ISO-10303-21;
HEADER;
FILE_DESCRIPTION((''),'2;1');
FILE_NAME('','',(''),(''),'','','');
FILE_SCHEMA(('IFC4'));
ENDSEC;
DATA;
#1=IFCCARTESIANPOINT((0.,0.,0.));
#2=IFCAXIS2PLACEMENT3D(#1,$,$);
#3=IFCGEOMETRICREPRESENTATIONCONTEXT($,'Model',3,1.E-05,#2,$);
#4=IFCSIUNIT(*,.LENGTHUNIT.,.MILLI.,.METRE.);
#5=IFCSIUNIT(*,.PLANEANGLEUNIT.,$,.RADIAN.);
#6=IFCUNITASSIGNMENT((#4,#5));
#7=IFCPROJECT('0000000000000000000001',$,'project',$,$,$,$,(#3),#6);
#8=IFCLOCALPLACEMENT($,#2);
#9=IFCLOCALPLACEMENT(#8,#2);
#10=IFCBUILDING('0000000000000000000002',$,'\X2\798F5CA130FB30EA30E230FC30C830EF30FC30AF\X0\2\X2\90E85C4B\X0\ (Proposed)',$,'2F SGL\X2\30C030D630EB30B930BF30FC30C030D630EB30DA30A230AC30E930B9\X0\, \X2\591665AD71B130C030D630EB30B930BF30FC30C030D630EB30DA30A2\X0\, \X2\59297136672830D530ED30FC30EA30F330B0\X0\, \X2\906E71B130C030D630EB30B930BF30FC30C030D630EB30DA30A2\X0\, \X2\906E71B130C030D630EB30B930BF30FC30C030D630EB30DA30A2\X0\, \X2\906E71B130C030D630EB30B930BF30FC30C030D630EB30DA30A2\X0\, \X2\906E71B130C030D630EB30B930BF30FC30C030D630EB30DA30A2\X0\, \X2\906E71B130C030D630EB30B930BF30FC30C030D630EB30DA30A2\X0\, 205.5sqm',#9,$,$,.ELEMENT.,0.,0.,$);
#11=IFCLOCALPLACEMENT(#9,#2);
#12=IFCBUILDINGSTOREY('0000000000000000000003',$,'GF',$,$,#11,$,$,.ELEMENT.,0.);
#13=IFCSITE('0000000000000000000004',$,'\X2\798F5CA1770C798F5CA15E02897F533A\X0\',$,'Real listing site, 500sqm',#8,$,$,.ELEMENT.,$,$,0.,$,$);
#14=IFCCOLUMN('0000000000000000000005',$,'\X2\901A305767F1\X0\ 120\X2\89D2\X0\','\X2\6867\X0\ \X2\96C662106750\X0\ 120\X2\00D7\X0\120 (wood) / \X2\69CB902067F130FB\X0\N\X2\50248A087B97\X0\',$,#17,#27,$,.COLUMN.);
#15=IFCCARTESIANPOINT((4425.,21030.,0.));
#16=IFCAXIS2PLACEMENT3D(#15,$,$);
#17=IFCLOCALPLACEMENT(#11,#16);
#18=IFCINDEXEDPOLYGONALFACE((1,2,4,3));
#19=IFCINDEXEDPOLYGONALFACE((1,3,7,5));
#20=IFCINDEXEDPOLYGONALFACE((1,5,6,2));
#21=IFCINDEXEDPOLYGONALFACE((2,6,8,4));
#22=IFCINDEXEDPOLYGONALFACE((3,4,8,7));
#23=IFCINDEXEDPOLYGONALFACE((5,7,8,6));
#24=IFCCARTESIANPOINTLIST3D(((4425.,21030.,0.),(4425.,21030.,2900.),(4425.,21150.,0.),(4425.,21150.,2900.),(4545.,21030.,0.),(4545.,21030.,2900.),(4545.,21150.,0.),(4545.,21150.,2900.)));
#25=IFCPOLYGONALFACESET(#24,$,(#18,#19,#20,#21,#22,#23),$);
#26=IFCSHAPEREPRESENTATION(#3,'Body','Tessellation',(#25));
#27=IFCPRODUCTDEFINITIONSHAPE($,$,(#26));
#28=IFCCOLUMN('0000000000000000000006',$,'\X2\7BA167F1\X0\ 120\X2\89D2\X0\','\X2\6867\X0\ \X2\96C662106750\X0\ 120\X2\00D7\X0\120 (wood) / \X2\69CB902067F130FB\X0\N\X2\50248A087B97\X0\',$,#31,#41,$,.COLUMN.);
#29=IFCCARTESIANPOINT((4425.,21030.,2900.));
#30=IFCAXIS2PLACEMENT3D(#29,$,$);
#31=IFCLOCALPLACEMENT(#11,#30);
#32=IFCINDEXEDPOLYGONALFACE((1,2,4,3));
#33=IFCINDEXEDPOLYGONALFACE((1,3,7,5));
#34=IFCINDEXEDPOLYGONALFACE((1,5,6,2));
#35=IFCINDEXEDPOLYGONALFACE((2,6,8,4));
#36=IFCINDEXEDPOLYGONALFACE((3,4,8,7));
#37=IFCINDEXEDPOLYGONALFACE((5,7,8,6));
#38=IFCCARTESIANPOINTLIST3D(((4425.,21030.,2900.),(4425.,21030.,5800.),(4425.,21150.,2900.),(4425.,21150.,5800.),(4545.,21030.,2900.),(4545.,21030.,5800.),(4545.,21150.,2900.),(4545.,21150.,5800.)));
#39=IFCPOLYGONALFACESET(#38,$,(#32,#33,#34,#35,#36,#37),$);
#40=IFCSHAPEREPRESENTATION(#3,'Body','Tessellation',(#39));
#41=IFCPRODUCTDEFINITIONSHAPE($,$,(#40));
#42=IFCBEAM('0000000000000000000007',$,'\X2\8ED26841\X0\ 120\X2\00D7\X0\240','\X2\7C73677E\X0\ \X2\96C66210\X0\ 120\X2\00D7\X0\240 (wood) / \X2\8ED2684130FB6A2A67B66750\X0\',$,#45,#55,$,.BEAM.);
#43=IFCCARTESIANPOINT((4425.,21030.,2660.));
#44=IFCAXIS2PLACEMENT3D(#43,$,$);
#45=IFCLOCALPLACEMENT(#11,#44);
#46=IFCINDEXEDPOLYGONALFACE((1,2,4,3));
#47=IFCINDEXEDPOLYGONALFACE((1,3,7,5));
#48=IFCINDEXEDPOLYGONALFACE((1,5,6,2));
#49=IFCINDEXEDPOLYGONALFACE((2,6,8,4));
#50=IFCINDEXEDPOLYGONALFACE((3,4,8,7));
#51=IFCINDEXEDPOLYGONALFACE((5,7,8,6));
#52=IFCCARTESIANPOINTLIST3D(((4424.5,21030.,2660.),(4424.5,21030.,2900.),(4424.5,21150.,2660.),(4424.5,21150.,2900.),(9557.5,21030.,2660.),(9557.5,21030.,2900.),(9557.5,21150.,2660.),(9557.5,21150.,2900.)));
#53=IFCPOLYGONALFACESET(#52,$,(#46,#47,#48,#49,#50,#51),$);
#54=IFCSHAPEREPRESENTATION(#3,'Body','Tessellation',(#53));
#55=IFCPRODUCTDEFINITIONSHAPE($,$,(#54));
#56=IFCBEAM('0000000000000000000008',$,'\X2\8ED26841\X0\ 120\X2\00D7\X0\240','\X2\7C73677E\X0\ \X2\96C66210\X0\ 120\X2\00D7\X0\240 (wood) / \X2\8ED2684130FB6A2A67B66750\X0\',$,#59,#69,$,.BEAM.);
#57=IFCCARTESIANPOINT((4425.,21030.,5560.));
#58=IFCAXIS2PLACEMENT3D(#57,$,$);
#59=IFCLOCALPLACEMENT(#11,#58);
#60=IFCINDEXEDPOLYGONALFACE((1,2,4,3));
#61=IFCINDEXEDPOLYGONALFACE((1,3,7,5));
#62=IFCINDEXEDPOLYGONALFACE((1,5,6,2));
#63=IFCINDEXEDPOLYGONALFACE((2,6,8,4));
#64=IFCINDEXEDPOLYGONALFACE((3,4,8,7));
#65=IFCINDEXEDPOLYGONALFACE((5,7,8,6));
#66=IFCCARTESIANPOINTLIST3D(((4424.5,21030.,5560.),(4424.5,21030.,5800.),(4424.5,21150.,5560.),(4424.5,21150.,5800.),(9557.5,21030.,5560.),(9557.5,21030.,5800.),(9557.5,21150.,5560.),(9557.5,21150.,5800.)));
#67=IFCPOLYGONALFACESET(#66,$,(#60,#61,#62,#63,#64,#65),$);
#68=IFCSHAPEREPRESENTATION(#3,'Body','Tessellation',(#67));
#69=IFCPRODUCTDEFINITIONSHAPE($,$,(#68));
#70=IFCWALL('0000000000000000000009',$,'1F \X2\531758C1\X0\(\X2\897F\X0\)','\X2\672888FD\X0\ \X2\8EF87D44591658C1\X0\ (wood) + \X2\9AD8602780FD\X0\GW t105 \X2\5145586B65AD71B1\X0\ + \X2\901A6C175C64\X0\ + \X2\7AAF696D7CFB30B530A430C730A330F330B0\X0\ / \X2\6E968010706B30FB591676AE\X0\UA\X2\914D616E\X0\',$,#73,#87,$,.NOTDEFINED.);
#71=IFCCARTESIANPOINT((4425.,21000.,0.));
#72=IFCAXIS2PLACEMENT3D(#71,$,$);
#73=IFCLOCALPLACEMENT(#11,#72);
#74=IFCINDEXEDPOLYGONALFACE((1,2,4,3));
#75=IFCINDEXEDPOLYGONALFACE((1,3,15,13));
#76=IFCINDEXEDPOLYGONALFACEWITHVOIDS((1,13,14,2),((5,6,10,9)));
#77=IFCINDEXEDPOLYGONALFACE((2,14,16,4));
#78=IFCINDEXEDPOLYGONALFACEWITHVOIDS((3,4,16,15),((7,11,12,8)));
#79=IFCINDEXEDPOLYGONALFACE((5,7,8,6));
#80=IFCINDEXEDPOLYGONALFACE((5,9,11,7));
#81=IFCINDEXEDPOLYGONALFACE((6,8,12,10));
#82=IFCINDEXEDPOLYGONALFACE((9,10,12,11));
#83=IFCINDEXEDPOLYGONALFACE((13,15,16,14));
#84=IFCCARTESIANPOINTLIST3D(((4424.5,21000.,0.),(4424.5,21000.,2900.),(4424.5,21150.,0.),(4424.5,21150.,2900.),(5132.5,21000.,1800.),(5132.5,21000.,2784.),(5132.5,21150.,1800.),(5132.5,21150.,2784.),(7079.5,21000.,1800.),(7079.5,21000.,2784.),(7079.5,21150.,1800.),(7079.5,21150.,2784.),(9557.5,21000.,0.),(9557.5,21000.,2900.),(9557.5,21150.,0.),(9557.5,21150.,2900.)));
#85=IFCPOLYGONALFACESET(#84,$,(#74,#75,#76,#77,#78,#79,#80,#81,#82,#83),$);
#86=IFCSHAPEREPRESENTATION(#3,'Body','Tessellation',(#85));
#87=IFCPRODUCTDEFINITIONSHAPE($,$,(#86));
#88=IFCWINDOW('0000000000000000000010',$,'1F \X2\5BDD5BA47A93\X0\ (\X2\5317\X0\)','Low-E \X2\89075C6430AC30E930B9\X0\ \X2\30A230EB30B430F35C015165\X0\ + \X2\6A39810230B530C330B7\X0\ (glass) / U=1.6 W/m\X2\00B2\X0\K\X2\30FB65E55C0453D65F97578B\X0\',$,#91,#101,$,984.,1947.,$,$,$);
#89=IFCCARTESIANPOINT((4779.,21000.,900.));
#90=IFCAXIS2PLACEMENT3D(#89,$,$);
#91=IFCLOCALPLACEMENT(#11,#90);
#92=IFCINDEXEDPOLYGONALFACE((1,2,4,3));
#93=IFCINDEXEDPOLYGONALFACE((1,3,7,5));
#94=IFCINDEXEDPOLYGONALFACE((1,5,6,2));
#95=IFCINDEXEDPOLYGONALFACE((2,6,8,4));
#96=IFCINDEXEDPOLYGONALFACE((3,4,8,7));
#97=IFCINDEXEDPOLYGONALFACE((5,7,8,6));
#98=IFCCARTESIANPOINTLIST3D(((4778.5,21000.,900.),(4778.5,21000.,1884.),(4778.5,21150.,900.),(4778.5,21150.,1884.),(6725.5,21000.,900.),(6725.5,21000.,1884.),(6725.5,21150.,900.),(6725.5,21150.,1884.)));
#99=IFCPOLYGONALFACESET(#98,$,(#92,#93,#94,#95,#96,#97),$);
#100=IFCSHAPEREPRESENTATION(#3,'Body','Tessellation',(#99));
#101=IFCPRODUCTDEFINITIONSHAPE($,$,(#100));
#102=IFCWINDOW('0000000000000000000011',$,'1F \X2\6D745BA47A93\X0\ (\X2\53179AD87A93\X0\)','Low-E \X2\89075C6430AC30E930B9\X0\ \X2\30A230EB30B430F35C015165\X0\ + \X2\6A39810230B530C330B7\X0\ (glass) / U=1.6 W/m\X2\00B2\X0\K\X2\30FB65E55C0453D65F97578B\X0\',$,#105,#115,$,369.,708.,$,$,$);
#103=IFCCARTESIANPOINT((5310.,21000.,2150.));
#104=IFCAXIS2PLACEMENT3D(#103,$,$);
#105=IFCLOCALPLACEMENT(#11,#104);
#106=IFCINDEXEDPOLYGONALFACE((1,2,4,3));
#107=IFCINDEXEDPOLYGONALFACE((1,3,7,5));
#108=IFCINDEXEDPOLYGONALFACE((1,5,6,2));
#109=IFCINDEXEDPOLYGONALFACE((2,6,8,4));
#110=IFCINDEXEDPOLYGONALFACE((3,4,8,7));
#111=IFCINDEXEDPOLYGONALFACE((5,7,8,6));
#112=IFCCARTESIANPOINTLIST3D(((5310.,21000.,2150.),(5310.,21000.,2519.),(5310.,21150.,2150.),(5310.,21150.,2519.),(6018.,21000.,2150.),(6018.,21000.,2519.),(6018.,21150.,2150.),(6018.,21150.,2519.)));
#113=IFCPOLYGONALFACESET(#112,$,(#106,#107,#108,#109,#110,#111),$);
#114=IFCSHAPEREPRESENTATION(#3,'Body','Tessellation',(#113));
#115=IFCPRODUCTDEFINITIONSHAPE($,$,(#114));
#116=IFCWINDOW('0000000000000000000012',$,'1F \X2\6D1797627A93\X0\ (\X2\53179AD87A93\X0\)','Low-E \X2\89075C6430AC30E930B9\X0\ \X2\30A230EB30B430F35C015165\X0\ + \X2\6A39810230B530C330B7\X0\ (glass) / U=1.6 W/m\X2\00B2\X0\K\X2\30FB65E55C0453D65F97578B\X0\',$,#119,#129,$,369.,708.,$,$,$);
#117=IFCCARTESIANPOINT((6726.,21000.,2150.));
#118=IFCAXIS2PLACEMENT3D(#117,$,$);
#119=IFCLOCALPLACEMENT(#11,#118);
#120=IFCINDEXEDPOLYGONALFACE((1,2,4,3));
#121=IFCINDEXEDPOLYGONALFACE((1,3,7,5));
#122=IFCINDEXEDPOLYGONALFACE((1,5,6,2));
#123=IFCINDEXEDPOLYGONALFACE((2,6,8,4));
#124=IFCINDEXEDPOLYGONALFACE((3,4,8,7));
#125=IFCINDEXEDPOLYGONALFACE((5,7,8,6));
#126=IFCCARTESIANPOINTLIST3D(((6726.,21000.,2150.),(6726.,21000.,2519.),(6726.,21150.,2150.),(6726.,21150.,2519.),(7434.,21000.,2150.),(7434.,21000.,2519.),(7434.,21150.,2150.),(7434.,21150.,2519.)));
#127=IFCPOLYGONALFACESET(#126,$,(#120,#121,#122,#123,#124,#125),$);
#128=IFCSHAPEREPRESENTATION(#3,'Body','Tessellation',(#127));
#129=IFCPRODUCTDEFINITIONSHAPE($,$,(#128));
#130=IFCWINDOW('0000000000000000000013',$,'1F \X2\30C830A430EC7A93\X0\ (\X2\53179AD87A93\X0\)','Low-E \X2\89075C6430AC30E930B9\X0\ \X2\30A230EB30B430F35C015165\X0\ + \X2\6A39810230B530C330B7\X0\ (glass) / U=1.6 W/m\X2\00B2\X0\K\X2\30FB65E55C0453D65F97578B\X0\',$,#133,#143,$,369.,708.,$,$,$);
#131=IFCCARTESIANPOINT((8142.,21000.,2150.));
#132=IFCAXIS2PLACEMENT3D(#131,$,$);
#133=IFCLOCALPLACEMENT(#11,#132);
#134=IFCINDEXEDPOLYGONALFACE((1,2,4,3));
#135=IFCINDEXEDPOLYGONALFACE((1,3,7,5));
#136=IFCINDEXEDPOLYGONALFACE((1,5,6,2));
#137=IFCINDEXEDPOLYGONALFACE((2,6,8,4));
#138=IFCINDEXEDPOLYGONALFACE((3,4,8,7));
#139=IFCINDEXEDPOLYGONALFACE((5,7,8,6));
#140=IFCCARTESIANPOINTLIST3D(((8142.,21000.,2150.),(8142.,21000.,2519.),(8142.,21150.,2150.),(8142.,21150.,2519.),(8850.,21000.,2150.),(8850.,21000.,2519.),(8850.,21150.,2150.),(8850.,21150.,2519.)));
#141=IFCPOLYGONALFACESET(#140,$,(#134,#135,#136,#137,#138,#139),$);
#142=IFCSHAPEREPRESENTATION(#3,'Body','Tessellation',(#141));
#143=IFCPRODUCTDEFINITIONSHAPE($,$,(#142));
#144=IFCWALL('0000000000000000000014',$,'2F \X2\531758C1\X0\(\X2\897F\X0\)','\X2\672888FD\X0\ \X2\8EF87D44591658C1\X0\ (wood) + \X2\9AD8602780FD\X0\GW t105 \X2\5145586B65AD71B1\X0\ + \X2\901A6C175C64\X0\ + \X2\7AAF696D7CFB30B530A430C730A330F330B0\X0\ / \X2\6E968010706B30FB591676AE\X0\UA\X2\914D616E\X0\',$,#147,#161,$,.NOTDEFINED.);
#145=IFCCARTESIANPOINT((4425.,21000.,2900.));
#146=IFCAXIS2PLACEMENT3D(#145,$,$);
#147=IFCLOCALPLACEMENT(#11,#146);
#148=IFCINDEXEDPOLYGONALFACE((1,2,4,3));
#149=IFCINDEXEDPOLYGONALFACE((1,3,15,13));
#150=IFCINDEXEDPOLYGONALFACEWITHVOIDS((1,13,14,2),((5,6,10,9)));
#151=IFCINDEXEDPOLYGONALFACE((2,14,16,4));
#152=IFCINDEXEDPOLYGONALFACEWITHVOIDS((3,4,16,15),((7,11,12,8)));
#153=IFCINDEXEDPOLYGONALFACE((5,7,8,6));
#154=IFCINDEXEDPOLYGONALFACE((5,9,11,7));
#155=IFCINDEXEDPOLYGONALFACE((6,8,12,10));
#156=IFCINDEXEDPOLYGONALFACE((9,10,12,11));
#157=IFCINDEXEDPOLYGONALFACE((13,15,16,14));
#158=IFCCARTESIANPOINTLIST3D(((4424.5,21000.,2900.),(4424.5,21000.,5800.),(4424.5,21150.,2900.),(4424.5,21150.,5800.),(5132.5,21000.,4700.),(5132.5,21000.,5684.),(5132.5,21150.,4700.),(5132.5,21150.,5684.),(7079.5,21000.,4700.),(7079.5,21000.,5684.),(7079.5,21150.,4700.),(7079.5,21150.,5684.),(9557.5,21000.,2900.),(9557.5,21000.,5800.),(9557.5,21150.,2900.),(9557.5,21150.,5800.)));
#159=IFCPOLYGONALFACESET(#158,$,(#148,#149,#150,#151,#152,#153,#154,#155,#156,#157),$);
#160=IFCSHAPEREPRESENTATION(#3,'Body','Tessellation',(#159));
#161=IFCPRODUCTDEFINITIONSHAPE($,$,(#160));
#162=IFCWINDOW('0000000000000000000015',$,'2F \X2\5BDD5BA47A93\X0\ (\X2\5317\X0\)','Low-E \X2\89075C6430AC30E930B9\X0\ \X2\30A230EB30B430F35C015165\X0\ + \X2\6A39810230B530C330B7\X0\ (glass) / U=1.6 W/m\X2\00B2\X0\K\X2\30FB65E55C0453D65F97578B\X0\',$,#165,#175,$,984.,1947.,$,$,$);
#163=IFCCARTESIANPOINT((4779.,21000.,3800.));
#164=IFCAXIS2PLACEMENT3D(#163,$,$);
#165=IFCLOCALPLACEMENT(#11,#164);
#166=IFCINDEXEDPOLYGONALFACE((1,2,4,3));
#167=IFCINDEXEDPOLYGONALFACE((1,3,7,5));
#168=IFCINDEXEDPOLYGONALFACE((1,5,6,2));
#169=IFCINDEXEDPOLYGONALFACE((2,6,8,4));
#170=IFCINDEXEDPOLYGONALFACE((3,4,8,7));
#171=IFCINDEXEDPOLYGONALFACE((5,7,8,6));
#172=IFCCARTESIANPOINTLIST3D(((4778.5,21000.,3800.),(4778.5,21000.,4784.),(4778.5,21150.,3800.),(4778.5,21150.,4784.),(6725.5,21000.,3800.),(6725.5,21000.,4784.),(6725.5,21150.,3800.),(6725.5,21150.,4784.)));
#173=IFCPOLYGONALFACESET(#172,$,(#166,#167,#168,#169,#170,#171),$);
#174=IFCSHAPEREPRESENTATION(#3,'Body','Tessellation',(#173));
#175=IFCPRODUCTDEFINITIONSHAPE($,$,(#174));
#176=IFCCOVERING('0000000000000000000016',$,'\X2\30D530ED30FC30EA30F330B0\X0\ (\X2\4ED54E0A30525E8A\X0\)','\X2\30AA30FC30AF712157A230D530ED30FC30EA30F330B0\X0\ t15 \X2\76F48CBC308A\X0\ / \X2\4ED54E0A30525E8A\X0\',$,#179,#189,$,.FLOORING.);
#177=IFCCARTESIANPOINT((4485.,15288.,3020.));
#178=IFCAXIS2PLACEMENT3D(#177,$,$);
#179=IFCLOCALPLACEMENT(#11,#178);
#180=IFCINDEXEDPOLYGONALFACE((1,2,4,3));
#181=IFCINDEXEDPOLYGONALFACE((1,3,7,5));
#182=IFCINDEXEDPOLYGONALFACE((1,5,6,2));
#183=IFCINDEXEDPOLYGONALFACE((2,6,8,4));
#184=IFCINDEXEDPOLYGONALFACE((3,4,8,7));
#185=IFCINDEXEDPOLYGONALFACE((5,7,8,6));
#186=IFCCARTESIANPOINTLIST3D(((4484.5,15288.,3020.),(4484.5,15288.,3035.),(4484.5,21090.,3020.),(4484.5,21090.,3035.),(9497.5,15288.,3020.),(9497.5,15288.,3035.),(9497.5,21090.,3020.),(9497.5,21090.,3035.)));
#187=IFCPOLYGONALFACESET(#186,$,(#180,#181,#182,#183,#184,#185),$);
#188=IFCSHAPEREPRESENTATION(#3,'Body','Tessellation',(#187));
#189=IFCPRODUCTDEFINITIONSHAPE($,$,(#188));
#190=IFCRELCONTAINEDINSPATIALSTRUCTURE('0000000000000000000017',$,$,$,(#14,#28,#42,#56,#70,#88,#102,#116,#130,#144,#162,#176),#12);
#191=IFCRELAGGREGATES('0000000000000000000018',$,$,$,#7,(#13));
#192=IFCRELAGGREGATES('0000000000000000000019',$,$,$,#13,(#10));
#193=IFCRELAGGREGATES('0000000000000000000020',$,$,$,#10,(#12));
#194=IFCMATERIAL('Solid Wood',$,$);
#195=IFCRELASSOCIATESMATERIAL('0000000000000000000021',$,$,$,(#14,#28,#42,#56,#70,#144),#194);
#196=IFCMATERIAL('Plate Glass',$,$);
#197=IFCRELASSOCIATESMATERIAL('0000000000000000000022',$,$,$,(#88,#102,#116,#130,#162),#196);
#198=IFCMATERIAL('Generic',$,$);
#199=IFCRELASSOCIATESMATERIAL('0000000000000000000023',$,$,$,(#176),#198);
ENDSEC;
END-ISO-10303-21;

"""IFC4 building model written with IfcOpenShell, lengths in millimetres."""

from ifc_helpers import new_model, si_unit, frame, frame_2d, origin, place, context, project, spatial, rectangle, extrude, material, element, fill, save


model = new_model("IFC4")

# Units and contexts
model_context = context("Model", 3, precision=1e-05, world=origin())
ifc_project = project(units=[si_unit("LENGTHUNIT", "METRE", prefix="MILLI"), si_unit("PLANEANGLEUNIT", "RADIAN")], contexts=[model_context])

# Site, building, storey
site_placement = place(None, origin())
site = spatial("IfcSite", under=ifc_project, at=site_placement, Name="福岡県福岡市西区", ObjectType="Real listing site, 500sqm", CompositionType="ELEMENT", RefElevation=0.0)
building_placement = place(site_placement, origin())
building = spatial("IfcBuilding", under=site, at=building_placement, Name="福岡・リモートワーク2部屋 (Proposed)", ObjectType="2F SGLダブルスターダブルペアガラス, 外断熱ダブルスターダブルペア, 天然木フローリング, 遮熱ダブルスターダブルペア, 遮熱ダブルスターダブルペア, 遮熱ダブルスターダブルペア, 遮熱ダブルスターダブルペア, 遮熱ダブルスターダブルペア, 205.5sqm", CompositionType="ELEMENT", ElevationOfRefHeight=0.0, ElevationOfTerrain=0.0)
storey_placement = place(building_placement, origin())
storey = spatial("IfcBuildingStorey", under=building, at=storey_placement, Name="GF", CompositionType="ELEMENT", Elevation=0.0)

# Columns
ifc_material_1 = material(Name="Solid Wood")
column_1_placement = place(storey_placement, frame((4425.0, 21030.0, 0.0)))
element("IfcColumn", 1, at=column_1_placement, inside=storey, material=ifc_material_1, Name="通し柱 120角", Description="桧 集成材 120×120 (wood) / 構造柱・N値計算", PredefinedType="COLUMN", context=model_context, shape_type="SweptSolid", body=[
    extrude(rectangle(XDim=120.0, YDim=120.0, at=frame_2d((60.0, 60.0))), frame((4425.0, 21030.0, 0.0)), (0.0, 0.0, 1.0), 2900.0),
])
column_2_placement = place(storey_placement, frame((4425.0, 21030.0, 2900.0)))
element("IfcColumn", 2, at=column_2_placement, inside=storey, material=ifc_material_1, Name="管柱 120角", Description="桧 集成材 120×120 (wood) / 構造柱・N値計算", PredefinedType="COLUMN", context=model_context, shape_type="SweptSolid", body=[
    extrude(rectangle(XDim=120.0, YDim=120.0, at=frame_2d((60.0, 60.0))), frame((4425.0, 21030.0, 2900.0)), (0.0, 0.0, 1.0), 2900.0),
])

# Beams
beam_1_placement = place(storey_placement, frame((4425.0, 21030.0, 2660.0)))
element("IfcBeam", 3, at=beam_1_placement, inside=storey, material=ifc_material_1, Name="軒桁 120×240", Description="米松 集成 120×240 (wood) / 軒桁・横架材", PredefinedType="BEAM", context=model_context, shape_type="SweptSolid", body=[
    extrude(rectangle(XDim=5133.0, YDim=120.0, at=frame_2d((2566.0, 60.0))), frame((4425.0, 21030.0, 2660.0)), (0.0, 0.0, 1.0), 240.0),
])
beam_2_placement = place(storey_placement, frame((4425.0, 21030.0, 5560.0)))
element("IfcBeam", 4, at=beam_2_placement, inside=storey, material=ifc_material_1, Name="軒桁 120×240", Description="米松 集成 120×240 (wood) / 軒桁・横架材", PredefinedType="BEAM", context=model_context, shape_type="SweptSolid", body=[
    extrude(rectangle(XDim=5133.0, YDim=120.0, at=frame_2d((2566.0, 60.0))), frame((4425.0, 21030.0, 5560.0)), (0.0, 0.0, 1.0), 240.0),
])

# Wall, openings, windows
wall_1_placement = place(storey_placement, frame((4425.0, 21000.0, 0.0)))
wall_1 = element("IfcWall", 5, at=wall_1_placement, inside=storey, material=ifc_material_1, Name="1F 北壁(西)", Description="木製 軸組外壁 (wood) + 高性能GW t105 充填断熱 + 通気層 + 窯業系サイディング / 準耐火・外皮UA配慮", PredefinedType="NOTDEFINED", context=model_context, shape_type="SweptSolid", body=[
    extrude(rectangle(XDim=5133.0, YDim=150.0, at=frame_2d((2566.0, 75.0))), frame((4425.0, 21000.0, 0.0)), (0.0, 0.0, 1.0), 2900.0),
])
opening_1_placement = place(storey_placement, frame((4779.0, 21000.0, 900.0)))
opening_1 = element("IfcOpeningElement", 6, at=opening_1_placement, cuts=wall_1, PredefinedType="NOTDEFINED", context=model_context, shape_type="SweptSolid", body=[
    extrude(rectangle(XDim=1947.0, YDim=150.0, at=frame_2d((973.0, 75.0))), frame((4779.0, 21000.0, 900.0)), (0.0, 0.0, 1.0), 984.0),
])
opening_2_placement = place(storey_placement, frame((5310.0, 21000.0, 2150.0)))
opening_2 = element("IfcOpeningElement", 7, at=opening_2_placement, cuts=wall_1, PredefinedType="NOTDEFINED", context=model_context, shape_type="SweptSolid", body=[
    extrude(rectangle(XDim=708.0, YDim=150.0, at=frame_2d((354.0, 75.0))), frame((5310.0, 21000.0, 2150.0)), (0.0, 0.0, 1.0), 369.0),
])
opening_3_placement = place(storey_placement, frame((6726.0, 21000.0, 2150.0)))
opening_3 = element("IfcOpeningElement", 8, at=opening_3_placement, cuts=wall_1, PredefinedType="NOTDEFINED", context=model_context, shape_type="SweptSolid", body=[
    extrude(rectangle(XDim=708.0, YDim=150.0, at=frame_2d((354.0, 75.0))), frame((6726.0, 21000.0, 2150.0)), (0.0, 0.0, 1.0), 369.0),
])
opening_4_placement = place(storey_placement, frame((8142.0, 21000.0, 2150.0)))
opening_4 = element("IfcOpeningElement", 9, at=opening_4_placement, cuts=wall_1, PredefinedType="NOTDEFINED", context=model_context, shape_type="SweptSolid", body=[
    extrude(rectangle(XDim=708.0, YDim=150.0, at=frame_2d((354.0, 75.0))), frame((8142.0, 21000.0, 2150.0)), (0.0, 0.0, 1.0), 369.0),
])
ifc_material_2 = material(Name="Plate Glass")
window_1_placement = place(storey_placement, frame((4779.0, 21000.0, 900.0)))
window_1 = element("IfcWindow", 10, at=window_1_placement, inside=storey, material=ifc_material_2, Name="1F 寝室窓 (北)", Description="Low-E 複層ガラス アルゴン封入 + 樹脂サッシ (glass) / U=1.6 W/m²K・日射取得型", OverallHeight=984.0, OverallWidth=1947.0, context=model_context, shape_type="SweptSolid", body=[
    extrude(rectangle(XDim=1947.0, YDim=150.0, at=frame_2d((973.0, 75.0))), frame((4779.0, 21000.0, 900.0)), (0.0, 0.0, 1.0), 984.0),
])
fill(opening_1, window_1)
window_2_placement = place(storey_placement, frame((5310.0, 21000.0, 2150.0)))
window_2 = element("IfcWindow", 11, at=window_2_placement, inside=storey, material=ifc_material_2, Name="1F 浴室窓 (北高窓)", Description="Low-E 複層ガラス アルゴン封入 + 樹脂サッシ (glass) / U=1.6 W/m²K・日射取得型", OverallHeight=369.0, OverallWidth=708.0, context=model_context, shape_type="SweptSolid", body=[
    extrude(rectangle(XDim=708.0, YDim=150.0, at=frame_2d((354.0, 75.0))), frame((5310.0, 21000.0, 2150.0)), (0.0, 0.0, 1.0), 369.0),
])
fill(opening_2, window_2)
window_3_placement = place(storey_placement, frame((6726.0, 21000.0, 2150.0)))
window_3 = element("IfcWindow", 12, at=window_3_placement, inside=storey, material=ifc_material_2, Name="1F 洗面窓 (北高窓)", Description="Low-E 複層ガラス アルゴン封入 + 樹脂サッシ (glass) / U=1.6 W/m²K・日射取得型", OverallHeight=369.0, OverallWidth=708.0, context=model_context, shape_type="SweptSolid", body=[
    extrude(rectangle(XDim=708.0, YDim=150.0, at=frame_2d((354.0, 75.0))), frame((6726.0, 21000.0, 2150.0)), (0.0, 0.0, 1.0), 369.0),
])
fill(opening_3, window_3)
window_4_placement = place(storey_placement, frame((8142.0, 21000.0, 2150.0)))
window_4 = element("IfcWindow", 13, at=window_4_placement, inside=storey, material=ifc_material_2, Name="1F トイレ窓 (北高窓)", Description="Low-E 複層ガラス アルゴン封入 + 樹脂サッシ (glass) / U=1.6 W/m²K・日射取得型", OverallHeight=369.0, OverallWidth=708.0, context=model_context, shape_type="SweptSolid", body=[
    extrude(rectangle(XDim=708.0, YDim=150.0, at=frame_2d((354.0, 75.0))), frame((8142.0, 21000.0, 2150.0)), (0.0, 0.0, 1.0), 369.0),
])
fill(opening_4, window_4)

# Wall, opening, window
wall_2_placement = place(storey_placement, frame((4425.0, 21000.0, 2900.0)))
wall_2 = element("IfcWall", 14, at=wall_2_placement, inside=storey, material=ifc_material_1, Name="2F 北壁(西)", Description="木製 軸組外壁 (wood) + 高性能GW t105 充填断熱 + 通気層 + 窯業系サイディング / 準耐火・外皮UA配慮", PredefinedType="NOTDEFINED", context=model_context, shape_type="SweptSolid", body=[
    extrude(rectangle(XDim=5133.0, YDim=150.0, at=frame_2d((2566.0, 75.0))), frame((4425.0, 21000.0, 2900.0)), (0.0, 0.0, 1.0), 2900.0),
])
opening_5_placement = place(storey_placement, frame((4779.0, 21000.0, 3800.0)))
opening_5 = element("IfcOpeningElement", 15, at=opening_5_placement, cuts=wall_2, PredefinedType="NOTDEFINED", context=model_context, shape_type="SweptSolid", body=[
    extrude(rectangle(XDim=1947.0, YDim=150.0, at=frame_2d((973.0, 75.0))), frame((4779.0, 21000.0, 3800.0)), (0.0, 0.0, 1.0), 984.0),
])
window_5_placement = place(storey_placement, frame((4779.0, 21000.0, 3800.0)))
window_5 = element("IfcWindow", 16, at=window_5_placement, inside=storey, material=ifc_material_2, Name="2F 寝室窓 (北)", Description="Low-E 複層ガラス アルゴン封入 + 樹脂サッシ (glass) / U=1.6 W/m²K・日射取得型", OverallHeight=984.0, OverallWidth=1947.0, context=model_context, shape_type="SweptSolid", body=[
    extrude(rectangle(XDim=1947.0, YDim=150.0, at=frame_2d((973.0, 75.0))), frame((4779.0, 21000.0, 3800.0)), (0.0, 0.0, 1.0), 984.0),
])
fill(opening_5, window_5)

# Covering
ifc_material_3 = material(Name="Generic")
covering_placement = place(storey_placement, frame((4485.0, 15288.0, 3020.0)))
element("IfcCovering", 17, at=covering_placement, inside=storey, material=ifc_material_3, Name="フローリング (仕上げ床)", Description="オーク無垢フローリング t15 直貼り / 仕上げ床", PredefinedType="FLOORING", context=model_context, shape_type="SweptSolid", body=[
    extrude(rectangle(XDim=5013.0, YDim=5802.0, at=frame_2d((2506.0, 2901.0))), frame((4485.0, 15288.0, 3020.0)), (0.0, 0.0, 1.0), 15.0),
])

save(model, "model.ifc")
